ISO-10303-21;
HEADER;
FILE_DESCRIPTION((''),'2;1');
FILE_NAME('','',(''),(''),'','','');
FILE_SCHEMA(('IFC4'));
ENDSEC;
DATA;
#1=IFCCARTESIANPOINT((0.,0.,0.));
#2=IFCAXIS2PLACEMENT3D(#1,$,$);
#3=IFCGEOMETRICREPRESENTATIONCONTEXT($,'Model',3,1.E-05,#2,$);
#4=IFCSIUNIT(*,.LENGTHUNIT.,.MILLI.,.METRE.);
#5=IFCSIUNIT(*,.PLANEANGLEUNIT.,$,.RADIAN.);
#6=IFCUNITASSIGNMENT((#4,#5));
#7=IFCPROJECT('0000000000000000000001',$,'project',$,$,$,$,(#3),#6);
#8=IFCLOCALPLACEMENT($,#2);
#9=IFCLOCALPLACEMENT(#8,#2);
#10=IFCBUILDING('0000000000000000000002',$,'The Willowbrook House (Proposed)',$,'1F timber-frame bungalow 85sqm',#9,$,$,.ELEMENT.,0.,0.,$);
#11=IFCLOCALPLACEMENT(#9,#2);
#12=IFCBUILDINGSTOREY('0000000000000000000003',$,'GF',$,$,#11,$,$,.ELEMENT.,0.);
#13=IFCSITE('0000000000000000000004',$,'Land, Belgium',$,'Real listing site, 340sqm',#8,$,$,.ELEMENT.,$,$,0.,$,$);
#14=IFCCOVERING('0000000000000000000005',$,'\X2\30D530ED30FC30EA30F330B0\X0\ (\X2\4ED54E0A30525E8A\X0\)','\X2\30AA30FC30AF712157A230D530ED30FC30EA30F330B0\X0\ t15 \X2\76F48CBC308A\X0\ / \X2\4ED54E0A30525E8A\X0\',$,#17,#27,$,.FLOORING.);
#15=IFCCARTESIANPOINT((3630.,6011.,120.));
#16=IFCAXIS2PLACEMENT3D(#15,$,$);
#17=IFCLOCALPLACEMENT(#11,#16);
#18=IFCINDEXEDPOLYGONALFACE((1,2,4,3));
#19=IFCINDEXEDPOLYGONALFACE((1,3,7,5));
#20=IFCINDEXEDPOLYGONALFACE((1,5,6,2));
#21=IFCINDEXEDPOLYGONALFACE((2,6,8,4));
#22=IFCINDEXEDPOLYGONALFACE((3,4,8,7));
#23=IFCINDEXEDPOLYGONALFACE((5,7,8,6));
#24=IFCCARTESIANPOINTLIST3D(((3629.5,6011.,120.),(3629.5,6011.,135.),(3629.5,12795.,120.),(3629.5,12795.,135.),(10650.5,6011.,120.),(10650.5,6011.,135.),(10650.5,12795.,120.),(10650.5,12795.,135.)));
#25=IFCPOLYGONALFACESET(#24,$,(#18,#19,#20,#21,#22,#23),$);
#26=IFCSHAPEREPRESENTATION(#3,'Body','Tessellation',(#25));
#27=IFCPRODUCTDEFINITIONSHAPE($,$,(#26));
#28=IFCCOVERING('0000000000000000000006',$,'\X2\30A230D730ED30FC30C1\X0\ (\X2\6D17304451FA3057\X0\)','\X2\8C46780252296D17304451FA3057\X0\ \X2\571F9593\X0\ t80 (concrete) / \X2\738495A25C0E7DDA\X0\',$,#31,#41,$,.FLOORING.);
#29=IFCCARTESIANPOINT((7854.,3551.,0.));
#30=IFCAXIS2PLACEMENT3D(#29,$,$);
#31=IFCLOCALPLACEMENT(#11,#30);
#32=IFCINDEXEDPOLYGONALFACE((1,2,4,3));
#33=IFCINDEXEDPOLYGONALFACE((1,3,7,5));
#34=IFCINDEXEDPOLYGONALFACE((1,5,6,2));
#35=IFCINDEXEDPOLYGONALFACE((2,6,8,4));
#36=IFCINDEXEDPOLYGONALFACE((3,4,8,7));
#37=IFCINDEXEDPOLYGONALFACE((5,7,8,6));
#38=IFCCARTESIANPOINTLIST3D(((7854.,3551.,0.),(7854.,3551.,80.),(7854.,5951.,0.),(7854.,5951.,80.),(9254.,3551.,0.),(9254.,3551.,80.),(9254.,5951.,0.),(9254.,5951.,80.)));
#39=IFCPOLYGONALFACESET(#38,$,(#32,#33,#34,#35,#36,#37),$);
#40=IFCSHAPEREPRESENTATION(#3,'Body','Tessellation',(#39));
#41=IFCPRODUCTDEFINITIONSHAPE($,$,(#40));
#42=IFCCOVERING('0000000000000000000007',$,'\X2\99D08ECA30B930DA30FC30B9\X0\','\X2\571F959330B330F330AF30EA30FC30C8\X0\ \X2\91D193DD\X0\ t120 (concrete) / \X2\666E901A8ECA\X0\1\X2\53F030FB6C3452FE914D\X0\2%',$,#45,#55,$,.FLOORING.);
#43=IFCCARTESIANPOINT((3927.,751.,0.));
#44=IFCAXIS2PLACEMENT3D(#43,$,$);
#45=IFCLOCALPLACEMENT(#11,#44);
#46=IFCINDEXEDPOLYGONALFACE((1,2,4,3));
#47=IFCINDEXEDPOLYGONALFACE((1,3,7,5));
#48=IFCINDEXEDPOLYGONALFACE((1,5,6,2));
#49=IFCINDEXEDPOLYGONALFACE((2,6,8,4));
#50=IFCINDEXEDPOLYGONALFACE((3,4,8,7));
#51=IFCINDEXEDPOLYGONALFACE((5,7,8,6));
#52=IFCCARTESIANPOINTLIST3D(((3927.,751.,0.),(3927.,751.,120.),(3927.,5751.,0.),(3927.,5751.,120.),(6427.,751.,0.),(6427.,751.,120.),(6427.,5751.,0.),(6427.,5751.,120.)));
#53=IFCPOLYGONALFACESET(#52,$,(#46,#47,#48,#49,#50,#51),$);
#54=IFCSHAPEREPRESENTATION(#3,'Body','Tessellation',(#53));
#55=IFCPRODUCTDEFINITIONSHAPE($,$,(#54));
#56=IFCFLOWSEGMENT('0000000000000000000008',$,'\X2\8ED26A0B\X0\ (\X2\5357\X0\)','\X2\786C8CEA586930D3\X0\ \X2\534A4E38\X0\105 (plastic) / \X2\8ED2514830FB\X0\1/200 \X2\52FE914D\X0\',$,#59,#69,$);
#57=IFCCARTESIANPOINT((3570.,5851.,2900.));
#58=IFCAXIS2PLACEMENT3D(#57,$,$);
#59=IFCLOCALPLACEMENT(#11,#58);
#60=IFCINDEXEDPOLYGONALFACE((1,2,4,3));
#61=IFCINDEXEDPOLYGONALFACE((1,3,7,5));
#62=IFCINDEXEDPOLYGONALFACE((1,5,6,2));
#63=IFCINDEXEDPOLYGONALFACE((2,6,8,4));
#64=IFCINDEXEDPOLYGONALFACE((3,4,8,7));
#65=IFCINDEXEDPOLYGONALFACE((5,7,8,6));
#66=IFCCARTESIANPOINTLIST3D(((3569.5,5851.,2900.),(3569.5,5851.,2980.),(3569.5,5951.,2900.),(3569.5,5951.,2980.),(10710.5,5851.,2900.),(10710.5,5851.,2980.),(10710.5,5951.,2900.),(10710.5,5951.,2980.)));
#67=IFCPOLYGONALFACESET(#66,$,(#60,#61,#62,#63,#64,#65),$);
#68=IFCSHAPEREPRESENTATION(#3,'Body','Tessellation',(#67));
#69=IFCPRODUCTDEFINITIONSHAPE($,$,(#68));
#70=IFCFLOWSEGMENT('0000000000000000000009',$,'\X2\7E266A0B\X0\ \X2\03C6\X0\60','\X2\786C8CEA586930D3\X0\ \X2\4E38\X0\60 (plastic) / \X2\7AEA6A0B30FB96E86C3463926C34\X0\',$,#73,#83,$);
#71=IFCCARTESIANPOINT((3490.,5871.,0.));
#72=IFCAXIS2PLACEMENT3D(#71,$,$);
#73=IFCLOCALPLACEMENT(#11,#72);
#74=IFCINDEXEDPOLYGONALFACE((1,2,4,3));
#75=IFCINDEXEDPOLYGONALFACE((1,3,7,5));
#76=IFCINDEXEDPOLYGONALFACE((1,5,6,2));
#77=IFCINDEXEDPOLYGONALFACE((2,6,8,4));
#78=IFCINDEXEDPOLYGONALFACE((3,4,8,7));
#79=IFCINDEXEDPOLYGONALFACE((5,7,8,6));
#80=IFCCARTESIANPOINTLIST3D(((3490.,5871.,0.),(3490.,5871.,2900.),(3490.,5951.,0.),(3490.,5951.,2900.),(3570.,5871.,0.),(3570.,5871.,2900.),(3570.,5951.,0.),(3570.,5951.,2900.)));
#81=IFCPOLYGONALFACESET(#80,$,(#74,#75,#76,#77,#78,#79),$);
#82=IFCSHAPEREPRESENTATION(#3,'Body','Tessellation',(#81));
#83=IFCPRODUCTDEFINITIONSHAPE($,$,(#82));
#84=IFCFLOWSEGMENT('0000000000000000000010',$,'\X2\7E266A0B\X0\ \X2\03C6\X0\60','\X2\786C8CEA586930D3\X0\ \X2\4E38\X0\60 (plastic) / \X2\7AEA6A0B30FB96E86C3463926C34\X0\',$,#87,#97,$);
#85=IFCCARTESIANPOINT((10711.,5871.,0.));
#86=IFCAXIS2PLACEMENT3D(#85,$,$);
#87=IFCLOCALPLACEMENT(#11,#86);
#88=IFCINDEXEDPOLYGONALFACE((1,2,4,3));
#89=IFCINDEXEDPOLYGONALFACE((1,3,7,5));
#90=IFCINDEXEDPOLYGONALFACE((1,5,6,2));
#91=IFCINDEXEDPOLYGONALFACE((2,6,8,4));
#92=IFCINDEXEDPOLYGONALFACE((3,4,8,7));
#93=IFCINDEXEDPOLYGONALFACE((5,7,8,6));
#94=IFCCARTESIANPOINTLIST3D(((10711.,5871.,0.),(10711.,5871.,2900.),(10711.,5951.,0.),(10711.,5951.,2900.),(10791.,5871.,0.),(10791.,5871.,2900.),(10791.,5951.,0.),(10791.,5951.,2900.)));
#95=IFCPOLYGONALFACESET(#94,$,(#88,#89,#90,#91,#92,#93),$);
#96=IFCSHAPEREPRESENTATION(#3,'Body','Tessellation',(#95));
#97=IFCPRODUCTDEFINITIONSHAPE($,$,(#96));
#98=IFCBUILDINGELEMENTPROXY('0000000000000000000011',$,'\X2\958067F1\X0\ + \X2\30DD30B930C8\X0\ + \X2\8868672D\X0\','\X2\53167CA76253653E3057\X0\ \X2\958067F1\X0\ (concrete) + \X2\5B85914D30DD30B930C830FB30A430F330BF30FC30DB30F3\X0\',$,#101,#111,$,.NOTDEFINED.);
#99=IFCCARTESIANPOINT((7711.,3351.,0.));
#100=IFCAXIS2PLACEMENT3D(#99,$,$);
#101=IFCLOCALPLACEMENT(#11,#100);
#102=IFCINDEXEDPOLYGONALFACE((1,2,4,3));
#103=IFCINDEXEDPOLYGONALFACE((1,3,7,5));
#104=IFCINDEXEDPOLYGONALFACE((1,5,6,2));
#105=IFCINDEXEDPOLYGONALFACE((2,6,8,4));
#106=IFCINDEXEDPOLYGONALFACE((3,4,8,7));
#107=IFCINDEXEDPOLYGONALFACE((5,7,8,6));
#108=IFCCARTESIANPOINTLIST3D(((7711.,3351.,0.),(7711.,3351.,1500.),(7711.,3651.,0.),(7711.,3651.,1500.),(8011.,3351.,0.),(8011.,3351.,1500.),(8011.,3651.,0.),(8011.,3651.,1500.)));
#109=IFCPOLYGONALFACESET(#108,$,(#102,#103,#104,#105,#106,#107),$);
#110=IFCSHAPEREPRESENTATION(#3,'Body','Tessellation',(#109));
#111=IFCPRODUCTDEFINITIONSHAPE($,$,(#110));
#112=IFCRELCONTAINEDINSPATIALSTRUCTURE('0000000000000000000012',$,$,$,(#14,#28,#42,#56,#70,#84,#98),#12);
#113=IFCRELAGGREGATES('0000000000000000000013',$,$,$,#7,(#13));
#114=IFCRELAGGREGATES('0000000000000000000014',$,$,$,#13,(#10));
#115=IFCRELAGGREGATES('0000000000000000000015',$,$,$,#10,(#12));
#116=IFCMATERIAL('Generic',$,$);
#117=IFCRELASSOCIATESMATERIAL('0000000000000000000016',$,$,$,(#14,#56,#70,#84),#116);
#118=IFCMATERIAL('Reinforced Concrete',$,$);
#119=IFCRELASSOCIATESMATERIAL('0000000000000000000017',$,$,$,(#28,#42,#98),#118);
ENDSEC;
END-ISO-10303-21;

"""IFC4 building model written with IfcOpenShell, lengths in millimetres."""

from ifc_helpers import new_model, si_unit, frame, frame_2d, origin, place, context, project, spatial, rectangle, extrude, material, element, save


model = new_model("IFC4")

# Units and contexts
model_context = context("Model", 3, precision=1e-05, world=origin())
ifc_project = project(units=[si_unit("LENGTHUNIT", "METRE", prefix="MILLI"), si_unit("PLANEANGLEUNIT", "RADIAN")], contexts=[model_context])

# Site, building, storey
site_placement = place(None, origin())
site = spatial("IfcSite", under=ifc_project, at=site_placement, Name="Land, Belgium", ObjectType="Real listing site, 340sqm", CompositionType="ELEMENT", RefElevation=0.0)
building_placement = place(site_placement, origin())
building = spatial("IfcBuilding", under=site, at=building_placement, Name="The Willowbrook House (Proposed)", ObjectType="1F timber-frame bungalow 85sqm", CompositionType="ELEMENT", ElevationOfRefHeight=0.0, ElevationOfTerrain=0.0)
storey_placement = place(building_placement, origin())
storey = spatial("IfcBuildingStorey", under=building, at=storey_placement, Name="GF", CompositionType="ELEMENT", Elevation=0.0)

# Shared definitions
ifc_material_1 = material(Name="Reinforced Concrete")

# Coverings
ifc_material_2 = material(Name="Generic")
covering_1_placement = place(storey_placement, frame((3630.0, 6011.0, 120.0)))
element("IfcCovering", 1, at=covering_1_placement, inside=storey, material=ifc_material_2, Name="フローリング (仕上げ床)", Description="オーク無垢フローリング t15 直貼り / 仕上げ床", PredefinedType="FLOORING", context=model_context, shape_type="SweptSolid", body=[
    extrude(rectangle(XDim=7021.0, YDim=6784.0, at=frame_2d((3510.0, 3392.0))), frame((3630.0, 6011.0, 120.0)), (0.0, 0.0, 1.0), 15.0),
])
covering_2_placement = place(storey_placement, frame((7854.0, 3551.0, 0.0)))
element("IfcCovering", 2, at=covering_2_placement, inside=storey, material=ifc_material_1, Name="アプローチ (洗い出し)", Description="豆砂利洗い出し 土間 t80 (concrete) / 玄関導線", PredefinedType="FLOORING", context=model_context, shape_type="SweptSolid", body=[
    extrude(rectangle(XDim=1400.0, YDim=2400.0, at=frame_2d((700.0, 1200.0))), frame((7854.0, 3551.0, 0.0)), (0.0, 0.0, 1.0), 80.0),
])
covering_3_placement = place(storey_placement, frame((3927.0, 751.0, 0.0)))
element("IfcCovering", 3, at=covering_3_placement, inside=storey, material=ifc_material_1, Name="駐車スペース", Description="土間コンクリート 金鏝 t120 (concrete) / 普通車1台・水勾配2%", PredefinedType="FLOORING", context=model_context, shape_type="SweptSolid", body=[
    extrude(rectangle(XDim=2500.0, YDim=5000.0, at=frame_2d((1250.0, 2500.0))), frame((3927.0, 751.0, 0.0)), (0.0, 0.0, 1.0), 120.0),
])

# Flow segments
flow_segment_1_placement = place(storey_placement, frame((3570.0, 5851.0, 2900.0)))
element("IfcFlowSegment", 4, at=flow_segment_1_placement, inside=storey, material=ifc_material_2, Name="軒樋 (南)", Description="硬質塩ビ 半丸105 (plastic) / 軒先・1/200 勾配", context=model_context, shape_type="SweptSolid", body=[
    extrude(rectangle(XDim=7141.0, YDim=100.0, at=frame_2d((3570.0, 50.0))), frame((3570.0, 5851.0, 2900.0)), (0.0, 0.0, 1.0), 80.0),
])
flow_segment_2_placement = place(storey_placement, frame((3490.0, 5871.0, 0.0)))
element("IfcFlowSegment", 5, at=flow_segment_2_placement, inside=storey, material=ifc_material_2, Name="縦樋 φ60", Description="硬質塩ビ 丸60 (plastic) / 竪樋・雨水排水", context=model_context, shape_type="SweptSolid", body=[
    extrude(rectangle(XDim=80.0, YDim=80.0, at=frame_2d((40.0, 40.0))), frame((3490.0, 5871.0, 0.0)), (0.0, 0.0, 1.0), 2900.0),
])
flow_segment_3_placement = place(storey_placement, frame((10711.0, 5871.0, 0.0)))
element("IfcFlowSegment", 6, at=flow_segment_3_placement, inside=storey, material=ifc_material_2, Name="縦樋 φ60", Description="硬質塩ビ 丸60 (plastic) / 竪樋・雨水排水", context=model_context, shape_type="SweptSolid", body=[
    extrude(rectangle(XDim=80.0, YDim=80.0, at=frame_2d((40.0, 40.0))), frame((10711.0, 5871.0, 0.0)), (0.0, 0.0, 1.0), 2900.0),
])

# Building element proxy
proxy_placement = place(storey_placement, frame((7711.0, 3351.0, 0.0)))
element("IfcBuildingElementProxy", 7, at=proxy_placement, inside=storey, material=ifc_material_1, Name="門柱 + ポスト + 表札", Description="化粧打放し 門柱 (concrete) + 宅配ポスト・インターホン", PredefinedType="NOTDEFINED", context=model_context, shape_type="SweptSolid", body=[
    extrude(rectangle(XDim=300.0, YDim=300.0, at=frame_2d((150.0, 150.0))), frame((7711.0, 3351.0, 0.0)), (0.0, 0.0, 1.0), 1500.0),
])

save(model, "model.ifc")
